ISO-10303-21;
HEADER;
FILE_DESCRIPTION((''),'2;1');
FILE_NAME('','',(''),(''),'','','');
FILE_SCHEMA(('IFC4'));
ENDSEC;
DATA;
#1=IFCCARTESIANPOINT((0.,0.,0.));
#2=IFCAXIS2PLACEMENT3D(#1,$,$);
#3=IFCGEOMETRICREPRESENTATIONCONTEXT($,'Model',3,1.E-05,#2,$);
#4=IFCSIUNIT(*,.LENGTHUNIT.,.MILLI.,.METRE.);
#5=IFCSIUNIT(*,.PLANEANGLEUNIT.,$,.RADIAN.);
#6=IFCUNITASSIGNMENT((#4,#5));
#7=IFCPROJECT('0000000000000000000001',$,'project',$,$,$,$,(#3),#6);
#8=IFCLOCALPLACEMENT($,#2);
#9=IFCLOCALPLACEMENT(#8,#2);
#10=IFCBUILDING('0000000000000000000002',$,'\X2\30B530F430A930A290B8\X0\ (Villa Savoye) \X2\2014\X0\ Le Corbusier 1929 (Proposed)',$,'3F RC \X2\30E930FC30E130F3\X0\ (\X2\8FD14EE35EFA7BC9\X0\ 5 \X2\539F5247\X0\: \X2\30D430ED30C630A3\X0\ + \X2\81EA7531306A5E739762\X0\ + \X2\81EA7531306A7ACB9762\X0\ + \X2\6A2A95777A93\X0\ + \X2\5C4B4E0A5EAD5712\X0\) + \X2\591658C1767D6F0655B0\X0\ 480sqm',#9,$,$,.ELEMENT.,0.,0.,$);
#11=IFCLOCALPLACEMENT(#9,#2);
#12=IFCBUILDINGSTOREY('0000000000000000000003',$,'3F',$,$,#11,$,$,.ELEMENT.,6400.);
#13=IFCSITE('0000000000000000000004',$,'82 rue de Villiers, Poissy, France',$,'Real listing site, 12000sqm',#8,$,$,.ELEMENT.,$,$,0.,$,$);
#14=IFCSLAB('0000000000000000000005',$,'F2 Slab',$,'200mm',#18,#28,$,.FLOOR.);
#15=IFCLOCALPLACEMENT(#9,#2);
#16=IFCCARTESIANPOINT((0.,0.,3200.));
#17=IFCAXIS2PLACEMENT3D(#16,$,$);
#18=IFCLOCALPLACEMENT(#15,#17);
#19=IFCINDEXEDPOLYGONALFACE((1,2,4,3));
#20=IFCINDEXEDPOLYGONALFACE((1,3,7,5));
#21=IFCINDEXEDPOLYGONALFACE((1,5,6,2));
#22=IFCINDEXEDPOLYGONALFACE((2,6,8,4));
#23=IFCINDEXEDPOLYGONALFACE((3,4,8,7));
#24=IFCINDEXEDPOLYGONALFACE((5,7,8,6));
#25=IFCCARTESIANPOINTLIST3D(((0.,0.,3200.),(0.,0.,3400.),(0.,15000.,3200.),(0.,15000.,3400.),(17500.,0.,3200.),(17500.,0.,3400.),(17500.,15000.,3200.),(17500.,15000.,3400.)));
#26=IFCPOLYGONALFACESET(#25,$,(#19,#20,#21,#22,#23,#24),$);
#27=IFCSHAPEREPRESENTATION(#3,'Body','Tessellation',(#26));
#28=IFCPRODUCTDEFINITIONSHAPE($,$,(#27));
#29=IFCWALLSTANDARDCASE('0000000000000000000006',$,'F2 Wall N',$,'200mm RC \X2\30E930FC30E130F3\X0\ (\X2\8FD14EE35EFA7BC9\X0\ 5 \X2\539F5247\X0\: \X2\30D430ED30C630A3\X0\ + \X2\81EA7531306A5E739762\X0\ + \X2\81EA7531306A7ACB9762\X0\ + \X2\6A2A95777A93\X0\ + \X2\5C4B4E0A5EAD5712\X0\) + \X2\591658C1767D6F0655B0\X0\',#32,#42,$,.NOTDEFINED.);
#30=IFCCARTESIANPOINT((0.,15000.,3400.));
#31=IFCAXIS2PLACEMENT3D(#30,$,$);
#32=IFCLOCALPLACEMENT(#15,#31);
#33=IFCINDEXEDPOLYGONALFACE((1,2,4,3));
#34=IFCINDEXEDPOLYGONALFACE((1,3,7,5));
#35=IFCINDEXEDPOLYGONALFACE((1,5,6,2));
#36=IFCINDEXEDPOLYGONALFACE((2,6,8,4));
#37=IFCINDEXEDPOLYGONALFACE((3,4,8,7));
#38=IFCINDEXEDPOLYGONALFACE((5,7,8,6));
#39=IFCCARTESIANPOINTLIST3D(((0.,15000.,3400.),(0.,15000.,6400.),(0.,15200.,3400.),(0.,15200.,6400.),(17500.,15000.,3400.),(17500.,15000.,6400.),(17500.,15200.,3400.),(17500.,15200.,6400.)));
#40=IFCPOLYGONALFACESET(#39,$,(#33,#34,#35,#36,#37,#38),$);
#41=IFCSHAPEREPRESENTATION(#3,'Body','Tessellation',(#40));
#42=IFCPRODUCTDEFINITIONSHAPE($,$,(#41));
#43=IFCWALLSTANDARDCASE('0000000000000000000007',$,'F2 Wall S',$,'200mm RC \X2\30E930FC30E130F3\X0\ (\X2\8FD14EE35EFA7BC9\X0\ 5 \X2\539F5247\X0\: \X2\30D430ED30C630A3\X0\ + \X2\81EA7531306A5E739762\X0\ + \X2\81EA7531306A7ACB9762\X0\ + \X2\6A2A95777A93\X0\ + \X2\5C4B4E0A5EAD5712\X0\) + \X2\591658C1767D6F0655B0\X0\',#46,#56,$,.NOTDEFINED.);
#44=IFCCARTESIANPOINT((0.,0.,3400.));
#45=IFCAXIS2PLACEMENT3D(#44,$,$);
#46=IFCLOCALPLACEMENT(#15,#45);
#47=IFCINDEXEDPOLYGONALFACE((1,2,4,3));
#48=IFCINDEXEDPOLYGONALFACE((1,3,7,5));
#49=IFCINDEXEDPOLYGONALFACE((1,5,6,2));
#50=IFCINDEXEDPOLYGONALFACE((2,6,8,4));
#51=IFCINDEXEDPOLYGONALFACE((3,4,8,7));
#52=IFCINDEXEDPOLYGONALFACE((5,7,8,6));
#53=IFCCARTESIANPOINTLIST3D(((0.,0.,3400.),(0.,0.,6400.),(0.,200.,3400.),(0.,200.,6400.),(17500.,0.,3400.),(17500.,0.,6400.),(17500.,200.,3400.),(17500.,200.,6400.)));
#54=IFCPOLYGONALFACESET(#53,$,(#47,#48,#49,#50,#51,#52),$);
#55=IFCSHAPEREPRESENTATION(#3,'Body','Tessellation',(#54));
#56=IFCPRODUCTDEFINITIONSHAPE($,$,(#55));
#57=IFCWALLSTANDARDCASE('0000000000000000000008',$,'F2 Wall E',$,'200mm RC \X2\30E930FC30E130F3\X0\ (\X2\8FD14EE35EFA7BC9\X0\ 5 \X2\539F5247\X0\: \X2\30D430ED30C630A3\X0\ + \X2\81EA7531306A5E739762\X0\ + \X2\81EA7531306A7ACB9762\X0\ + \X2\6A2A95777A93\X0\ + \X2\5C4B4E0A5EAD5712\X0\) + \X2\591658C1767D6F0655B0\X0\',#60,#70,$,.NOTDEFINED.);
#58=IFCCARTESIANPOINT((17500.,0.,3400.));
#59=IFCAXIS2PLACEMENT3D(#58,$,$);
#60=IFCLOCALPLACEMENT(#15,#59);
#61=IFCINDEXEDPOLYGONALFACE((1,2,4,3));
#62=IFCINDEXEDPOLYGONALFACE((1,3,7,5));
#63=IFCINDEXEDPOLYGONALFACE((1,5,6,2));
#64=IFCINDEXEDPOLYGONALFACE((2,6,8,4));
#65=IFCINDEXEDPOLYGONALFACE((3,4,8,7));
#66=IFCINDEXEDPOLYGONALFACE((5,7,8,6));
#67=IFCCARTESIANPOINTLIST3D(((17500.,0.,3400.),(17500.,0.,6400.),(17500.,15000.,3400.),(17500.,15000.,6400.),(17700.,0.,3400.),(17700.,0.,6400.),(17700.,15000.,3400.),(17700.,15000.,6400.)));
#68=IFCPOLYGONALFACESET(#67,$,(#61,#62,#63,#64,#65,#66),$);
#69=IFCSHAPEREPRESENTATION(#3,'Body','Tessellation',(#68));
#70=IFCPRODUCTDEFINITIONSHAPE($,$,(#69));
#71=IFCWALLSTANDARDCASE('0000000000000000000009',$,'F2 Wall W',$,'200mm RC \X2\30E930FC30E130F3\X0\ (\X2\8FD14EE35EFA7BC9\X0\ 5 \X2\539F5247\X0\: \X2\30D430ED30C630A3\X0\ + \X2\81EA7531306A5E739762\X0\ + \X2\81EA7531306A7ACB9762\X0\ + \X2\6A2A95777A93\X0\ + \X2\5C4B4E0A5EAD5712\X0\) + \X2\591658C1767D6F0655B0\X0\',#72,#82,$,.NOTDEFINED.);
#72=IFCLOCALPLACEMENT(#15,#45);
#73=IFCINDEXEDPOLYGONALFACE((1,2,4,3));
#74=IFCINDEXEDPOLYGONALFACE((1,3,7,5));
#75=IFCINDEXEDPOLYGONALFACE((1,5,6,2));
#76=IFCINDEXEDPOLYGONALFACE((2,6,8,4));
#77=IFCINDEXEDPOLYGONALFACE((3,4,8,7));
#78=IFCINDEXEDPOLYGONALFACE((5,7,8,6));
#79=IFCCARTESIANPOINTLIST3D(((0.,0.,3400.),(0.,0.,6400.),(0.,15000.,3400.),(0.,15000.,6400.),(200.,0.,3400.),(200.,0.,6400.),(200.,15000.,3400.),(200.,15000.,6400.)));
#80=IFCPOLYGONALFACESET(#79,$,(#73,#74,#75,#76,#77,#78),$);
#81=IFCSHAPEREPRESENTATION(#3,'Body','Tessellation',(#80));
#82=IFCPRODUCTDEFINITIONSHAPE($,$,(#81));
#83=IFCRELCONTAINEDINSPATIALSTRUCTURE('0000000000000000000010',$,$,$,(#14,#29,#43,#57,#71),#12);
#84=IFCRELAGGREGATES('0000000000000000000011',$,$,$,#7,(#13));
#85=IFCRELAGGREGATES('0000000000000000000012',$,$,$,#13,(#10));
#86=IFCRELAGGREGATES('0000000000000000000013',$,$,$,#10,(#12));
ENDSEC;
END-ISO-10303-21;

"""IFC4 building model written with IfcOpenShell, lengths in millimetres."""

from ifc_helpers import new_model, si_unit, frame, frame_2d, origin, place, context, project, spatial, rectangle, extrude, element, save


model = new_model("IFC4")

# Units and contexts
model_context = context("Model", 3, precision=1e-05, world=origin())
ifc_project = project(units=[si_unit("LENGTHUNIT", "METRE", prefix="MILLI"), si_unit("PLANEANGLEUNIT", "RADIAN")], contexts=[model_context])

# Site, building, storey
site_placement = place(None, origin())
site = spatial("IfcSite", under=ifc_project, at=site_placement, Name="82 rue de Villiers, Poissy, France", ObjectType="Real listing site, 12000sqm", CompositionType="ELEMENT", RefElevation=0.0)
building_placement = place(site_placement, origin())
building = spatial("IfcBuilding", under=site, at=building_placement, Name="サヴォア邸 (Villa Savoye) — Le Corbusier 1929 (Proposed)", ObjectType="3F RC ラーメン (近代建築 5 原則: ピロティ + 自由な平面 + 自由な立面 + 横長窓 + 屋上庭園) + 外壁白漆喰 480sqm", CompositionType="ELEMENT", ElevationOfRefHeight=0.0, ElevationOfTerrain=0.0)
storey_placement = place(building_placement, origin())
storey = spatial("IfcBuildingStorey", under=building, at=storey_placement, Name="3F", CompositionType="ELEMENT", Elevation=6400.0)

# Slab
placement = place(building_placement, origin())
slab_placement = place(placement, frame((0.0, 0.0, 3200.0)))
element("IfcSlab", 1, at=slab_placement, inside=storey, Name="F2 Slab", ObjectType="200mm", PredefinedType="FLOOR", context=model_context, shape_type="SweptSolid", body=[
    extrude(rectangle(XDim=17500.0, YDim=15000.0, at=frame_2d((8750.0, 7500.0))), frame((0.0, 0.0, 3200.0)), (0.0, 0.0, 1.0), 200.0),
])

# Walls
wall_1_placement = place(placement, frame((0.0, 15000.0, 3400.0)))
element("IfcWallStandardCase", 2, at=wall_1_placement, inside=storey, Name="F2 Wall N", ObjectType="200mm RC ラーメン (近代建築 5 原則: ピロティ + 自由な平面 + 自由な立面 + 横長窓 + 屋上庭園) + 外壁白漆喰", PredefinedType="NOTDEFINED", context=model_context, shape_type="SweptSolid", body=[
    extrude(rectangle(XDim=17500.0, YDim=200.0, at=frame_2d((8750.0, 100.0))), frame((0.0, 15000.0, 3400.0)), (0.0, 0.0, 1.0), 3000.0),
])
wall_2_placement = place(placement, frame((0.0, 0.0, 3400.0)))
element("IfcWallStandardCase", 3, at=wall_2_placement, inside=storey, Name="F2 Wall S", ObjectType="200mm RC ラーメン (近代建築 5 原則: ピロティ + 自由な平面 + 自由な立面 + 横長窓 + 屋上庭園) + 外壁白漆喰", PredefinedType="NOTDEFINED", context=model_context, shape_type="SweptSolid", body=[
    extrude(rectangle(XDim=17500.0, YDim=200.0, at=frame_2d((8750.0, 100.0))), frame((0.0, 0.0, 3400.0)), (0.0, 0.0, 1.0), 3000.0),
])
wall_3_placement = place(placement, frame((17500.0, 0.0, 3400.0)))
element("IfcWallStandardCase", 4, at=wall_3_placement, inside=storey, Name="F2 Wall E", ObjectType="200mm RC ラーメン (近代建築 5 原則: ピロティ + 自由な平面 + 自由な立面 + 横長窓 + 屋上庭園) + 外壁白漆喰", PredefinedType="NOTDEFINED", context=model_context, shape_type="SweptSolid", body=[
    extrude(rectangle(XDim=200.0, YDim=15000.0, at=frame_2d((100.0, 7500.0))), frame((17500.0, 0.0, 3400.0)), (0.0, 0.0, 1.0), 3000.0),
])
wall_4_placement = place(placement, frame((0.0, 0.0, 3400.0)))
element("IfcWallStandardCase", 5, at=wall_4_placement, inside=storey, Name="F2 Wall W", ObjectType="200mm RC ラーメン (近代建築 5 原則: ピロティ + 自由な平面 + 自由な立面 + 横長窓 + 屋上庭園) + 外壁白漆喰", PredefinedType="NOTDEFINED", context=model_context, shape_type="SweptSolid", body=[
    extrude(rectangle(XDim=200.0, YDim=15000.0, at=frame_2d((100.0, 7500.0))), frame((0.0, 0.0, 3400.0)), (0.0, 0.0, 1.0), 3000.0),
])

save(model, "model.ifc")
